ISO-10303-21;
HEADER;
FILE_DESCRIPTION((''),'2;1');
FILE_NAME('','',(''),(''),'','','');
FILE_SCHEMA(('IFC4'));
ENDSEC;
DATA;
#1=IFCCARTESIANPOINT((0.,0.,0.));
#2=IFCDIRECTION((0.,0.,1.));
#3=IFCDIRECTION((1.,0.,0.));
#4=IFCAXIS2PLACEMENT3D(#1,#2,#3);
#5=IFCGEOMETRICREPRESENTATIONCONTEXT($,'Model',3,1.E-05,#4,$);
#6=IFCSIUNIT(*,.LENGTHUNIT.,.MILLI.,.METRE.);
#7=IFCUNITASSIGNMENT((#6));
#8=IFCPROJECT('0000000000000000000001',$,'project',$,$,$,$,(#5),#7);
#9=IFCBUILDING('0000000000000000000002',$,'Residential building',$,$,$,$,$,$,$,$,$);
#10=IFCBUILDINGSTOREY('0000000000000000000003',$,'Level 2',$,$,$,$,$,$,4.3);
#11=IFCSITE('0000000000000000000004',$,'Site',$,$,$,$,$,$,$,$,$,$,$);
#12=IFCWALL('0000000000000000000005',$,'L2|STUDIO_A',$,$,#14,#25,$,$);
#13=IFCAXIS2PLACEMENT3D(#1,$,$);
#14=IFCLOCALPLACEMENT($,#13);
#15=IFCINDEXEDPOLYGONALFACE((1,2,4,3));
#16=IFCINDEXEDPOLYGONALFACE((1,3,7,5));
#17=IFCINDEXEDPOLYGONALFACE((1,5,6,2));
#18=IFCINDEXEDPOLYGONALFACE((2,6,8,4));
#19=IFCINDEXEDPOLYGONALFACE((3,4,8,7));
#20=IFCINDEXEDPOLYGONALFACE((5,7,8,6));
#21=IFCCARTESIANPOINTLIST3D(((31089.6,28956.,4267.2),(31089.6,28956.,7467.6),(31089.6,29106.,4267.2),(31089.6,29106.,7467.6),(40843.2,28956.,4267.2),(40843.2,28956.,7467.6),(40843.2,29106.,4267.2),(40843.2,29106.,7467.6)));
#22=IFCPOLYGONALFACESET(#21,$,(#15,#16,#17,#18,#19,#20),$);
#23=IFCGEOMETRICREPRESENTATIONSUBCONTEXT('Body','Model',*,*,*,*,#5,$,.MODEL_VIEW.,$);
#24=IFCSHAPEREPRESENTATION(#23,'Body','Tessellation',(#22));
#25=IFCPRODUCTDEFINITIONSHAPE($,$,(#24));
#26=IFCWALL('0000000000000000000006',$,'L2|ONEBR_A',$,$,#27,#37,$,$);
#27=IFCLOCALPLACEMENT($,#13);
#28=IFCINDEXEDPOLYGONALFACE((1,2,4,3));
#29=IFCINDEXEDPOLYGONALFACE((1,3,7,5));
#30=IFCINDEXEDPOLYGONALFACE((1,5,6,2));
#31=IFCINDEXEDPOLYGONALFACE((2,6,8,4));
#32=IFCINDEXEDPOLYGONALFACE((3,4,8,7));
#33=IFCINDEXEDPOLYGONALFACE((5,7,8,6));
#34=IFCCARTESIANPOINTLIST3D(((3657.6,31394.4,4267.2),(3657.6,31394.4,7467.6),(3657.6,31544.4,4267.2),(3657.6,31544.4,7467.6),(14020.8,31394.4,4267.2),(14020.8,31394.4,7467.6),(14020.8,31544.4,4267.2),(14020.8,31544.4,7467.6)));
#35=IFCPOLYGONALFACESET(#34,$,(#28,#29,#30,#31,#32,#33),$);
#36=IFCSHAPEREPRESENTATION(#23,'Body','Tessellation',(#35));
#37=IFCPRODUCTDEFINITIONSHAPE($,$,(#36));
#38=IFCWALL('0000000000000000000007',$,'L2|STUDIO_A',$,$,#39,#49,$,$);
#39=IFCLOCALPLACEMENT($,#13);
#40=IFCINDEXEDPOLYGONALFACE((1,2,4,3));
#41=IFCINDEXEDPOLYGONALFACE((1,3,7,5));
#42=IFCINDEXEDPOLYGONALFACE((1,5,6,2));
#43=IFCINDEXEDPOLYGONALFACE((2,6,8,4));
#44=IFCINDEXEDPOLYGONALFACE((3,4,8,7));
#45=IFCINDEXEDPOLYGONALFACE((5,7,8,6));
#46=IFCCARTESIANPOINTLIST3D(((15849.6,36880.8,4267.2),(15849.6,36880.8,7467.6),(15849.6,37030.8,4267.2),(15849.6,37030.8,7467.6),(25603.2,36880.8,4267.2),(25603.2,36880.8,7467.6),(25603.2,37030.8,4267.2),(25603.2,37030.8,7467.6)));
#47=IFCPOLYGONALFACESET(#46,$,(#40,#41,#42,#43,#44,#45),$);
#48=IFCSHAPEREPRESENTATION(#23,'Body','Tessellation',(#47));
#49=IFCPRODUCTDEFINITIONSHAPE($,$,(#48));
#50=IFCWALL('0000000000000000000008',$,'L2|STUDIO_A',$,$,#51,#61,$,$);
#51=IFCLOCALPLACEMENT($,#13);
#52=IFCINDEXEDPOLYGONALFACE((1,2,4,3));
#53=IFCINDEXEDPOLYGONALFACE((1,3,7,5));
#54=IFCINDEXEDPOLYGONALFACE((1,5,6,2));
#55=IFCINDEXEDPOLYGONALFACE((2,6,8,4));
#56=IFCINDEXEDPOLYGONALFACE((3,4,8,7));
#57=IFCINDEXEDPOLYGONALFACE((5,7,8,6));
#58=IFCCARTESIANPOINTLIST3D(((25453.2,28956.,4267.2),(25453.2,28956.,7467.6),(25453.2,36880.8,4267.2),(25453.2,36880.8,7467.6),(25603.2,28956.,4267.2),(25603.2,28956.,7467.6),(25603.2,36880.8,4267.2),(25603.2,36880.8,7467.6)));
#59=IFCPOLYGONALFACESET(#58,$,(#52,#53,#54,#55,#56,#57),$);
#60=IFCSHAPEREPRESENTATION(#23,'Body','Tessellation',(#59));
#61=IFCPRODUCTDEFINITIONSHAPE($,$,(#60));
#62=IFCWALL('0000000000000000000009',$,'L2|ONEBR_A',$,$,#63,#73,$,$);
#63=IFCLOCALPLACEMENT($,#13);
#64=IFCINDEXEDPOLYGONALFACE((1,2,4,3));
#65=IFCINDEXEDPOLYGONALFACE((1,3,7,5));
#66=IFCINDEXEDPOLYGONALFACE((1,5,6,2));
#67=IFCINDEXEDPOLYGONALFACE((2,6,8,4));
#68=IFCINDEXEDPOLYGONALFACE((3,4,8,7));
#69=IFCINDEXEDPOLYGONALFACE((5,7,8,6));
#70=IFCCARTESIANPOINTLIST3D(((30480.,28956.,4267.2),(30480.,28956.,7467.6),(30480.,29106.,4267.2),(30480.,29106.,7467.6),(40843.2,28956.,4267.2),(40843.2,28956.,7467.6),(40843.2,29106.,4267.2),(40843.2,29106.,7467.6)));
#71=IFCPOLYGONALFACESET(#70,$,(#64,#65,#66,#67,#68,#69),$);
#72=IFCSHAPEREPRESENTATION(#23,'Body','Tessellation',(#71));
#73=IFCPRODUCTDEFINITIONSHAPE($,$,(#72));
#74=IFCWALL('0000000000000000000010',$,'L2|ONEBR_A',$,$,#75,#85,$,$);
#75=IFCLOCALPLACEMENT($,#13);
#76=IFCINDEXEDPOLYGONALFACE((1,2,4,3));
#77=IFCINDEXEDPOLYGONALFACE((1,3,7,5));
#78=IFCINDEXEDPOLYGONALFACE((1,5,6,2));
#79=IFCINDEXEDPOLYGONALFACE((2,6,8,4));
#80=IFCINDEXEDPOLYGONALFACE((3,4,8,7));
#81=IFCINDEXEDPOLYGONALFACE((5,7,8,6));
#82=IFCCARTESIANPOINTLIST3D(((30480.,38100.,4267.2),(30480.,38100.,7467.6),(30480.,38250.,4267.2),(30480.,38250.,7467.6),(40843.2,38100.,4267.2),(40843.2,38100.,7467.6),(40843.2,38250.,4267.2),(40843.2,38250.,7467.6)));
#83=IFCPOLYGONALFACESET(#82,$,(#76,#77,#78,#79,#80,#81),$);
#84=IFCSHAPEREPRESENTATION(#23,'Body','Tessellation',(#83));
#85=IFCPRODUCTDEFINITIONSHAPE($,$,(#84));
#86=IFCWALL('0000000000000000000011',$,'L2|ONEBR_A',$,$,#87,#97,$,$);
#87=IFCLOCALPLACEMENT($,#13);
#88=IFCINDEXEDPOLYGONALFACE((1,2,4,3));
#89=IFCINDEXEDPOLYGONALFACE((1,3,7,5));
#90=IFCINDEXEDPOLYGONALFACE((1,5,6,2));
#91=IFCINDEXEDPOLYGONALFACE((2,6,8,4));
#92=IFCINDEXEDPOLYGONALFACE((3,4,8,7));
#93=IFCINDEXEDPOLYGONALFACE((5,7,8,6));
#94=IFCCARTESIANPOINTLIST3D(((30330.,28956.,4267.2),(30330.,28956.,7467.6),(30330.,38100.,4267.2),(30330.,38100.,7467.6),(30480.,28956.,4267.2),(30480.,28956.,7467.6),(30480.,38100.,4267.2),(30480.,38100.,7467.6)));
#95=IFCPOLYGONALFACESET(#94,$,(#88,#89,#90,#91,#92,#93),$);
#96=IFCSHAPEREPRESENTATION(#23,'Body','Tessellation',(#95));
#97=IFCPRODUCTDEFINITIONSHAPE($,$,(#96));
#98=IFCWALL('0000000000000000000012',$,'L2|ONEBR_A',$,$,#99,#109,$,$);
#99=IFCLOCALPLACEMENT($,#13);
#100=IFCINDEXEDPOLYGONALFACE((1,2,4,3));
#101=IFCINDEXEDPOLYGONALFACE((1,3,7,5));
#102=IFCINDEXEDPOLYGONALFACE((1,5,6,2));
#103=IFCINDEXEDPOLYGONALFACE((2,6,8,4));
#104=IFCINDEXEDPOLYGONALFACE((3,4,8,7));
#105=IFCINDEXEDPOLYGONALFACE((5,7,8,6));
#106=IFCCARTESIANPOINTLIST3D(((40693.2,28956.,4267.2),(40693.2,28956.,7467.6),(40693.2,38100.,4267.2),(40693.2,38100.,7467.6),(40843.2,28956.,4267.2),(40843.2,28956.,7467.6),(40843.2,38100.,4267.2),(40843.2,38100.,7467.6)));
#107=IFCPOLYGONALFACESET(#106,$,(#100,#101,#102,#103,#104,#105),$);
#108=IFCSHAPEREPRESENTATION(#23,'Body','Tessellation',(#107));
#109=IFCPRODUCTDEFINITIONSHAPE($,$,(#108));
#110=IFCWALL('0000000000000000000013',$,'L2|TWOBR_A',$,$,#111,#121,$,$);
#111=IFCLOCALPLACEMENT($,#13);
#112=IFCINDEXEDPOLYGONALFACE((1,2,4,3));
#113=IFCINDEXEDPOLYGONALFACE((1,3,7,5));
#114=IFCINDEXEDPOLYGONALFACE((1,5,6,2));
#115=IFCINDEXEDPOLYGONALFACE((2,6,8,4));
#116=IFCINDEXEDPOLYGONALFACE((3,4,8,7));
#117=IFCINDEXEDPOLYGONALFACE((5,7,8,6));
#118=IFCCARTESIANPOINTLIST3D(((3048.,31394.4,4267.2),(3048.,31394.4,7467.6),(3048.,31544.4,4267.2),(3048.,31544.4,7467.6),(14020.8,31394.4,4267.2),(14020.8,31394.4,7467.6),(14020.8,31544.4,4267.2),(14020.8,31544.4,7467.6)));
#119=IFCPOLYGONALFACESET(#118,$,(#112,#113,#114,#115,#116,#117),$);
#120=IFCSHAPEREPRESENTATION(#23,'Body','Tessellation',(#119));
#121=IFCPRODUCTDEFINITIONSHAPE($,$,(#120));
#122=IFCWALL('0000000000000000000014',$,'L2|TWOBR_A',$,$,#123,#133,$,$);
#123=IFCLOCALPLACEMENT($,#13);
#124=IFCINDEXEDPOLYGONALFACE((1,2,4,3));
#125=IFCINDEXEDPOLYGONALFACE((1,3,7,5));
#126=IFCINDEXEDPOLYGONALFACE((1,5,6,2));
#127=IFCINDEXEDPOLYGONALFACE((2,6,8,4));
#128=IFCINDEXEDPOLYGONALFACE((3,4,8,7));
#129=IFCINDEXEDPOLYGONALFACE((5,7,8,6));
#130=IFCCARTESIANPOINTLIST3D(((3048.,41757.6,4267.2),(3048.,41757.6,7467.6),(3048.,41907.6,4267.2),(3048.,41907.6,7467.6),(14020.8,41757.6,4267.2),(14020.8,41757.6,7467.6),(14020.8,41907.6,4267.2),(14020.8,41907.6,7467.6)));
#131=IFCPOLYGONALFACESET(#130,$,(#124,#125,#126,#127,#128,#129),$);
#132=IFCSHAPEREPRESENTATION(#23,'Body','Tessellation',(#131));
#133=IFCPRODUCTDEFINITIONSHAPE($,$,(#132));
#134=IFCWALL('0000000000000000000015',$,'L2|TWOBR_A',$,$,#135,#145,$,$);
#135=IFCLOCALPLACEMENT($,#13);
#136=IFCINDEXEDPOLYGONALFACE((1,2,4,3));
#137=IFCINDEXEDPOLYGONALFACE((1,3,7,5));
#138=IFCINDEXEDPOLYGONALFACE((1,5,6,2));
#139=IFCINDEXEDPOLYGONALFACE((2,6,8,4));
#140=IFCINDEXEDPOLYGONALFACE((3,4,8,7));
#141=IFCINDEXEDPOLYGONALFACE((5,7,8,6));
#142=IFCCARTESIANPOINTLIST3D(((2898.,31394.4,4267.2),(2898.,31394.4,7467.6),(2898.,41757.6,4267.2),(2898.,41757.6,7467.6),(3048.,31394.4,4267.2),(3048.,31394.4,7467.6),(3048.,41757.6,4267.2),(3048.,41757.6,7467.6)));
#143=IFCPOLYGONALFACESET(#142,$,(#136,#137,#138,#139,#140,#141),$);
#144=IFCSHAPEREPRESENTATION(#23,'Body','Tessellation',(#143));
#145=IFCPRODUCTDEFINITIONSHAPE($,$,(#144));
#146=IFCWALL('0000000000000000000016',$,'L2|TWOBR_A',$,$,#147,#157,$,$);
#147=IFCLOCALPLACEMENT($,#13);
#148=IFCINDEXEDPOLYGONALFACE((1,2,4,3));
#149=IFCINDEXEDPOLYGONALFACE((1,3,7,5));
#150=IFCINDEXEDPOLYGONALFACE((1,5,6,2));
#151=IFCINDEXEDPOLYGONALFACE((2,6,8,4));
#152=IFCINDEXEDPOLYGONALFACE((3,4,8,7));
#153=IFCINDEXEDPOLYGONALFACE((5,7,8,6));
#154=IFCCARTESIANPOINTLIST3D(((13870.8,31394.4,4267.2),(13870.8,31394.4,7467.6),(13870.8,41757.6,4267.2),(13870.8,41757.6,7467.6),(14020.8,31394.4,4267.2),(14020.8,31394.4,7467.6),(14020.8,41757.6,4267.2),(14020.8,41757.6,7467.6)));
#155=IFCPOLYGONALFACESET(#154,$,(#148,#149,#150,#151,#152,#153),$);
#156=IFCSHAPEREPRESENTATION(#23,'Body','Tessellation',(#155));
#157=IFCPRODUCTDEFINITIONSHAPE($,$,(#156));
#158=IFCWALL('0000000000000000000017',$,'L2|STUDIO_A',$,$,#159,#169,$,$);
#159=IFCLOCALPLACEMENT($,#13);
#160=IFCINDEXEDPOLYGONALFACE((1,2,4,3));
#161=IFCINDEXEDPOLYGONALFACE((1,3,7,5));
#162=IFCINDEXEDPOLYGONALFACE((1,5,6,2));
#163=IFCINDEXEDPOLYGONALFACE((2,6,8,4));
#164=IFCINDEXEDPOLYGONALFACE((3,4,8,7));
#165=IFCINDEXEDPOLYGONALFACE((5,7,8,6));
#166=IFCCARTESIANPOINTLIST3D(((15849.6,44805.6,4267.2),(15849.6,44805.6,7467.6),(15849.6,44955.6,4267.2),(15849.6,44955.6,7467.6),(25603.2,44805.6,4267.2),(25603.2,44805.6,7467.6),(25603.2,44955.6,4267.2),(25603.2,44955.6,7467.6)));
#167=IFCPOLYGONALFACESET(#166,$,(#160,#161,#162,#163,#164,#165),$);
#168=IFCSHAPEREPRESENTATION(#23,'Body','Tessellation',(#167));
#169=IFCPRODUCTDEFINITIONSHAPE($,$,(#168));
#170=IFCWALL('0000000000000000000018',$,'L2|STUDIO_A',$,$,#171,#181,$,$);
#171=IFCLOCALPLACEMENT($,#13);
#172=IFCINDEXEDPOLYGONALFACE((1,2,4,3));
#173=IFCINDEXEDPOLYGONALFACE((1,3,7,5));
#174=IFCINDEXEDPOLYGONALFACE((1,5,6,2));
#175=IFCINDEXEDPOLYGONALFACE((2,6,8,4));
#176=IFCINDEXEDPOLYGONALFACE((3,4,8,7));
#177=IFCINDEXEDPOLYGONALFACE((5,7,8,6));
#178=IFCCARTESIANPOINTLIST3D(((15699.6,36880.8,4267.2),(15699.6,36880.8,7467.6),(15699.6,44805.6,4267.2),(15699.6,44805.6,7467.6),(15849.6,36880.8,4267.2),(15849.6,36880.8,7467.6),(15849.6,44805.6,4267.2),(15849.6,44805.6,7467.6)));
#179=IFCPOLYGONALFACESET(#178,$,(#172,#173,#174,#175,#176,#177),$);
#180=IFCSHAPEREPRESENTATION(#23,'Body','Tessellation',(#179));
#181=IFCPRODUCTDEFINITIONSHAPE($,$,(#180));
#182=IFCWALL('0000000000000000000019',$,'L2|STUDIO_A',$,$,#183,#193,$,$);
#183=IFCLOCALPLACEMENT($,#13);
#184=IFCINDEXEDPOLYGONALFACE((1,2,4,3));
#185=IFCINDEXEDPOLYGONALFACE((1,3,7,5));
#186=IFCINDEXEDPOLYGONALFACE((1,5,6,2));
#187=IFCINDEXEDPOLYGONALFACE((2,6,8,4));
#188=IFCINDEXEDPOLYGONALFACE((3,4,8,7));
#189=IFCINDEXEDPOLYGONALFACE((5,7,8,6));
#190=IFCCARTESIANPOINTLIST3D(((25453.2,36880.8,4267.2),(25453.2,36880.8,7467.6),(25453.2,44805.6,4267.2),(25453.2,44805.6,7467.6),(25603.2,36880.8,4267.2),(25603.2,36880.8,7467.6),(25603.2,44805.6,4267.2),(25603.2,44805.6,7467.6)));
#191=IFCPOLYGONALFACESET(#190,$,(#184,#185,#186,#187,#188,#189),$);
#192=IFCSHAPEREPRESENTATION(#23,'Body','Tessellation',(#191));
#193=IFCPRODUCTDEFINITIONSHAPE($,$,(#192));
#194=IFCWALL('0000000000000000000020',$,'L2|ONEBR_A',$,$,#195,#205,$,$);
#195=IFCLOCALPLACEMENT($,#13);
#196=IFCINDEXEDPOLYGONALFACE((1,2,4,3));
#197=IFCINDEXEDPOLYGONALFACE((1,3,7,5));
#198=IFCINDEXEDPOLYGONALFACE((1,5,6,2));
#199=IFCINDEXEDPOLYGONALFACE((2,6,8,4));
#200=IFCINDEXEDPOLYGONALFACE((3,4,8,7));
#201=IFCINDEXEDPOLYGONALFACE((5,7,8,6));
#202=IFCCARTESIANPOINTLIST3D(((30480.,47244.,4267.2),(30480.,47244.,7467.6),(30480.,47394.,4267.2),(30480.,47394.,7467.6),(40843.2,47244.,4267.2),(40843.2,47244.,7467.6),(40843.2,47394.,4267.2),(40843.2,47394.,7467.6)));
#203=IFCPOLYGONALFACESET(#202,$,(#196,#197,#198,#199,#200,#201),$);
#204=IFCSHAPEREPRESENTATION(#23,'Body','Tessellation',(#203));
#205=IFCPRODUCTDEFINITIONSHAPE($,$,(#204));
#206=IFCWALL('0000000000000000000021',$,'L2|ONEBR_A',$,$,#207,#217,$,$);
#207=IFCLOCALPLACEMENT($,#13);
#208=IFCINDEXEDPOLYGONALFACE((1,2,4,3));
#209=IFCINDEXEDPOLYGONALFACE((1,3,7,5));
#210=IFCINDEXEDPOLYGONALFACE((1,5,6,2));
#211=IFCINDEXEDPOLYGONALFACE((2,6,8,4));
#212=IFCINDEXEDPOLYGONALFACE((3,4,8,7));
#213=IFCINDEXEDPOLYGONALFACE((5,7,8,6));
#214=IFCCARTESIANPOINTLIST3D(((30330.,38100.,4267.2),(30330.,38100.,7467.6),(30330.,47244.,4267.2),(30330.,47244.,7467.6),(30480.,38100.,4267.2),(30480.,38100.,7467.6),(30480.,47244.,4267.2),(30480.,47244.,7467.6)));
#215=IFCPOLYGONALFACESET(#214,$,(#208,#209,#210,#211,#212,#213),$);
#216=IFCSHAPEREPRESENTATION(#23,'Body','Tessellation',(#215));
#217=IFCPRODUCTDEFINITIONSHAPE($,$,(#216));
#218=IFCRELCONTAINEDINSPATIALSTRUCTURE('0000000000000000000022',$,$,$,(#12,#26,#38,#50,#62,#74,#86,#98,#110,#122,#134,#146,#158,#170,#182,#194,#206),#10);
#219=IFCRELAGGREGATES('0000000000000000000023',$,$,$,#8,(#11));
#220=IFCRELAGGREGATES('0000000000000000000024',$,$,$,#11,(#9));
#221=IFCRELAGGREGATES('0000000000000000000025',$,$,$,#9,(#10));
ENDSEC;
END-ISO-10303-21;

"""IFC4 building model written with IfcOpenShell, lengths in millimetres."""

from ifc_helpers import new_model, si_unit, frame, origin_with_axes, place, context, subcontext, project, spatial, indexed_curve, outline, extrude, element, save


model = new_model("IFC4")

# Units and contexts
model_context = context("Model", 3, precision=1e-05, world=origin_with_axes())
body_context = subcontext(model_context, "Body", "Model", "MODEL_VIEW")
ifc_project = project(units=[si_unit("LENGTHUNIT", "METRE", prefix="MILLI")], contexts=[model_context])

# Site, building, storey
site = spatial("IfcSite", under=ifc_project, Name="Site")
building = spatial("IfcBuilding", under=site, Name="Residential building")
storey = spatial("IfcBuildingStorey", under=building, Name="Level 2", Elevation=4.3)

# Walls
wall_1_placement = place(None, frame((31089.6, 28956.0, 4267.2), z_axis=(0.0, 0.0, 1.0), x_axis=(1.0, 0.0, 0.0)))
element("IfcWall", 1, at=wall_1_placement, inside=storey, Name="L2|STUDIO_A", context=body_context, shape_type="SweptSolid", body=[
    extrude(outline(indexed_curve([(0.0, 0.0), (0.0, 150.0), (9753.6, 150.0), (9753.6, 0.0), (0.0, 0.0)], self_intersect=False)), origin_with_axes(), (0.0, 0.0, 1.0), 3200.4),
])
wall_2_placement = place(None, frame((3657.6, 31394.4, 4267.2), z_axis=(0.0, 0.0, 1.0), x_axis=(1.0, 0.0, 0.0)))
element("IfcWall", 2, at=wall_2_placement, inside=storey, Name="L2|ONEBR_A", context=body_context, shape_type="SweptSolid", body=[
    extrude(outline(indexed_curve([(0.0, 0.0), (0.0, 150.0), (10363.2, 150.0), (10363.2, 0.0), (0.0, 0.0)], self_intersect=False)), origin_with_axes(), (0.0, 0.0, 1.0), 3200.4),
])
wall_3_placement = place(None, frame((15849.6, 36880.8, 4267.2), z_axis=(0.0, 0.0, 1.0), x_axis=(1.0, 0.0, 0.0)))
element("IfcWall", 3, at=wall_3_placement, inside=storey, Name="L2|STUDIO_A", context=body_context, shape_type="SweptSolid", body=[
    extrude(outline(indexed_curve([(0.0, 0.0), (0.0, 150.0), (9753.6, 150.0), (9753.6, 0.0), (0.0, 0.0)], self_intersect=False)), origin_with_axes(), (0.0, 0.0, 1.0), 3200.4),
])
wall_4_placement = place(None, frame((25603.2, 28956.0, 4267.2), z_axis=(0.0, 0.0, 1.0), x_axis=(0.0, 1.0, 0.0)))
element("IfcWall", 4, at=wall_4_placement, inside=storey, Name="L2|STUDIO_A", context=body_context, shape_type="SweptSolid", body=[
    extrude(outline(indexed_curve([(0.0, 0.0), (0.0, 150.0), (7924.8, 150.0), (7924.8, 0.0), (0.0, 0.0)], self_intersect=False)), origin_with_axes(), (0.0, 0.0, 1.0), 3200.4),
])
for number, where, z_axis, x_axis, name in (
    (5, (30480.0, 28956.0, 4267.2), (0.0, 0.0, 1.0), (1.0, 0.0, 0.0), "L2|ONEBR_A"),
    (6, (30480.0, 38100.0, 4267.2), (0.0, 0.0, 1.0), (1.0, 0.0, 0.0), "L2|ONEBR_A"),
):
    element("IfcWall", number, at=place(None, frame(where, z_axis=z_axis, x_axis=x_axis)), inside=storey, Name=name, context=body_context, shape_type="SweptSolid", body=[
        extrude(outline(indexed_curve([(0.0, 0.0), (0.0, 150.0), (10363.2, 150.0), (10363.2, 0.0), (0.0, 0.0)], self_intersect=False)), origin_with_axes(), (0.0, 0.0, 1.0), 3200.4),
    ])
for number, where, z_axis, x_axis, name in (
    (7, (30480.0, 28956.0, 4267.2), (0.0, 0.0, 1.0), (0.0, 1.0, 0.0), "L2|ONEBR_A"),
    (8, (40843.2, 28956.0, 4267.2), (0.0, 0.0, 1.0), (0.0, 1.0, 0.0), "L2|ONEBR_A"),
):
    element("IfcWall", number, at=place(None, frame(where, z_axis=z_axis, x_axis=x_axis)), inside=storey, Name=name, context=body_context, shape_type="SweptSolid", body=[
        extrude(outline(indexed_curve([(0.0, 0.0), (0.0, 150.0), (9144.0, 150.0), (9144.0, 0.0), (0.0, 0.0)], self_intersect=False)), origin_with_axes(), (0.0, 0.0, 1.0), 3200.4),
    ])
for number, where, z_axis, x_axis, name in (
    (9, (3048.0, 31394.4, 4267.2), (0.0, 0.0, 1.0), (1.0, 0.0, 0.0), "L2|TWOBR_A"),
    (10, (3048.0, 41757.6, 4267.2), (0.0, 0.0, 1.0), (1.0, 0.0, 0.0), "L2|TWOBR_A"),
):
    element("IfcWall", number, at=place(None, frame(where, z_axis=z_axis, x_axis=x_axis)), inside=storey, Name=name, context=body_context, shape_type="SweptSolid", body=[
        extrude(outline(indexed_curve([(0.0, 0.0), (0.0, 150.0), (10972.8, 150.0), (10972.8, 0.0), (0.0, 0.0)], self_intersect=False)), origin_with_axes(), (0.0, 0.0, 1.0), 3200.4),
    ])
for number, where, z_axis, x_axis, name in (
    (11, (3048.0, 31394.4, 4267.2), (0.0, 0.0, 1.0), (0.0, 1.0, 0.0), "L2|TWOBR_A"),
    (12, (14020.8, 31394.4, 4267.2), (0.0, 0.0, 1.0), (0.0, 1.0, 0.0), "L2|TWOBR_A"),
):
    element("IfcWall", number, at=place(None, frame(where, z_axis=z_axis, x_axis=x_axis)), inside=storey, Name=name, context=body_context, shape_type="SweptSolid", body=[
        extrude(outline(indexed_curve([(0.0, 0.0), (0.0, 150.0), (10363.2, 150.0), (10363.2, 0.0), (0.0, 0.0)], self_intersect=False)), origin_with_axes(), (0.0, 0.0, 1.0), 3200.4),
    ])
for number, where, z_axis, x_axis, name in (
    (13, (15849.6, 44805.6, 4267.2), (0.0, 0.0, 1.0), (1.0, 0.0, 0.0), "L2|STUDIO_A"),
):
    element("IfcWall", number, at=place(None, frame(where, z_axis=z_axis, x_axis=x_axis)), inside=storey, Name=name, context=body_context, shape_type="SweptSolid", body=[
        extrude(outline(indexed_curve([(0.0, 0.0), (0.0, 150.0), (9753.6, 150.0), (9753.6, 0.0), (0.0, 0.0)], self_intersect=False)), origin_with_axes(), (0.0, 0.0, 1.0), 3200.4),
    ])
for number, where, z_axis, x_axis, name in (
    (14, (15849.6, 36880.8, 4267.2), (0.0, 0.0, 1.0), (0.0, 1.0, 0.0), "L2|STUDIO_A"),
    (15, (25603.2, 36880.8, 4267.2), (0.0, 0.0, 1.0), (0.0, 1.0, 0.0), "L2|STUDIO_A"),
):
    element("IfcWall", number, at=place(None, frame(where, z_axis=z_axis, x_axis=x_axis)), inside=storey, Name=name, context=body_context, shape_type="SweptSolid", body=[
        extrude(outline(indexed_curve([(0.0, 0.0), (0.0, 150.0), (7924.8, 150.0), (7924.8, 0.0), (0.0, 0.0)], self_intersect=False)), origin_with_axes(), (0.0, 0.0, 1.0), 3200.4),
    ])
for number, where, z_axis, x_axis, name in (
    (16, (30480.0, 47244.0, 4267.2), (0.0, 0.0, 1.0), (1.0, 0.0, 0.0), "L2|ONEBR_A"),
):
    element("IfcWall", number, at=place(None, frame(where, z_axis=z_axis, x_axis=x_axis)), inside=storey, Name=name, context=body_context, shape_type="SweptSolid", body=[
        extrude(outline(indexed_curve([(0.0, 0.0), (0.0, 150.0), (10363.2, 150.0), (10363.2, 0.0), (0.0, 0.0)], self_intersect=False)), origin_with_axes(), (0.0, 0.0, 1.0), 3200.4),
    ])
wall_5_placement = place(None, frame((30480.0, 38100.0, 4267.2), z_axis=(0.0, 0.0, 1.0), x_axis=(0.0, 1.0, 0.0)))
element("IfcWall", 17, at=wall_5_placement, inside=storey, Name="L2|ONEBR_A", context=body_context, shape_type="SweptSolid", body=[
    extrude(outline(indexed_curve([(0.0, 0.0), (0.0, 150.0), (9144.0, 150.0), (9144.0, 0.0), (0.0, 0.0)], self_intersect=False)), origin_with_axes(), (0.0, 0.0, 1.0), 3200.4),
])

save(model, "model.ifc")
